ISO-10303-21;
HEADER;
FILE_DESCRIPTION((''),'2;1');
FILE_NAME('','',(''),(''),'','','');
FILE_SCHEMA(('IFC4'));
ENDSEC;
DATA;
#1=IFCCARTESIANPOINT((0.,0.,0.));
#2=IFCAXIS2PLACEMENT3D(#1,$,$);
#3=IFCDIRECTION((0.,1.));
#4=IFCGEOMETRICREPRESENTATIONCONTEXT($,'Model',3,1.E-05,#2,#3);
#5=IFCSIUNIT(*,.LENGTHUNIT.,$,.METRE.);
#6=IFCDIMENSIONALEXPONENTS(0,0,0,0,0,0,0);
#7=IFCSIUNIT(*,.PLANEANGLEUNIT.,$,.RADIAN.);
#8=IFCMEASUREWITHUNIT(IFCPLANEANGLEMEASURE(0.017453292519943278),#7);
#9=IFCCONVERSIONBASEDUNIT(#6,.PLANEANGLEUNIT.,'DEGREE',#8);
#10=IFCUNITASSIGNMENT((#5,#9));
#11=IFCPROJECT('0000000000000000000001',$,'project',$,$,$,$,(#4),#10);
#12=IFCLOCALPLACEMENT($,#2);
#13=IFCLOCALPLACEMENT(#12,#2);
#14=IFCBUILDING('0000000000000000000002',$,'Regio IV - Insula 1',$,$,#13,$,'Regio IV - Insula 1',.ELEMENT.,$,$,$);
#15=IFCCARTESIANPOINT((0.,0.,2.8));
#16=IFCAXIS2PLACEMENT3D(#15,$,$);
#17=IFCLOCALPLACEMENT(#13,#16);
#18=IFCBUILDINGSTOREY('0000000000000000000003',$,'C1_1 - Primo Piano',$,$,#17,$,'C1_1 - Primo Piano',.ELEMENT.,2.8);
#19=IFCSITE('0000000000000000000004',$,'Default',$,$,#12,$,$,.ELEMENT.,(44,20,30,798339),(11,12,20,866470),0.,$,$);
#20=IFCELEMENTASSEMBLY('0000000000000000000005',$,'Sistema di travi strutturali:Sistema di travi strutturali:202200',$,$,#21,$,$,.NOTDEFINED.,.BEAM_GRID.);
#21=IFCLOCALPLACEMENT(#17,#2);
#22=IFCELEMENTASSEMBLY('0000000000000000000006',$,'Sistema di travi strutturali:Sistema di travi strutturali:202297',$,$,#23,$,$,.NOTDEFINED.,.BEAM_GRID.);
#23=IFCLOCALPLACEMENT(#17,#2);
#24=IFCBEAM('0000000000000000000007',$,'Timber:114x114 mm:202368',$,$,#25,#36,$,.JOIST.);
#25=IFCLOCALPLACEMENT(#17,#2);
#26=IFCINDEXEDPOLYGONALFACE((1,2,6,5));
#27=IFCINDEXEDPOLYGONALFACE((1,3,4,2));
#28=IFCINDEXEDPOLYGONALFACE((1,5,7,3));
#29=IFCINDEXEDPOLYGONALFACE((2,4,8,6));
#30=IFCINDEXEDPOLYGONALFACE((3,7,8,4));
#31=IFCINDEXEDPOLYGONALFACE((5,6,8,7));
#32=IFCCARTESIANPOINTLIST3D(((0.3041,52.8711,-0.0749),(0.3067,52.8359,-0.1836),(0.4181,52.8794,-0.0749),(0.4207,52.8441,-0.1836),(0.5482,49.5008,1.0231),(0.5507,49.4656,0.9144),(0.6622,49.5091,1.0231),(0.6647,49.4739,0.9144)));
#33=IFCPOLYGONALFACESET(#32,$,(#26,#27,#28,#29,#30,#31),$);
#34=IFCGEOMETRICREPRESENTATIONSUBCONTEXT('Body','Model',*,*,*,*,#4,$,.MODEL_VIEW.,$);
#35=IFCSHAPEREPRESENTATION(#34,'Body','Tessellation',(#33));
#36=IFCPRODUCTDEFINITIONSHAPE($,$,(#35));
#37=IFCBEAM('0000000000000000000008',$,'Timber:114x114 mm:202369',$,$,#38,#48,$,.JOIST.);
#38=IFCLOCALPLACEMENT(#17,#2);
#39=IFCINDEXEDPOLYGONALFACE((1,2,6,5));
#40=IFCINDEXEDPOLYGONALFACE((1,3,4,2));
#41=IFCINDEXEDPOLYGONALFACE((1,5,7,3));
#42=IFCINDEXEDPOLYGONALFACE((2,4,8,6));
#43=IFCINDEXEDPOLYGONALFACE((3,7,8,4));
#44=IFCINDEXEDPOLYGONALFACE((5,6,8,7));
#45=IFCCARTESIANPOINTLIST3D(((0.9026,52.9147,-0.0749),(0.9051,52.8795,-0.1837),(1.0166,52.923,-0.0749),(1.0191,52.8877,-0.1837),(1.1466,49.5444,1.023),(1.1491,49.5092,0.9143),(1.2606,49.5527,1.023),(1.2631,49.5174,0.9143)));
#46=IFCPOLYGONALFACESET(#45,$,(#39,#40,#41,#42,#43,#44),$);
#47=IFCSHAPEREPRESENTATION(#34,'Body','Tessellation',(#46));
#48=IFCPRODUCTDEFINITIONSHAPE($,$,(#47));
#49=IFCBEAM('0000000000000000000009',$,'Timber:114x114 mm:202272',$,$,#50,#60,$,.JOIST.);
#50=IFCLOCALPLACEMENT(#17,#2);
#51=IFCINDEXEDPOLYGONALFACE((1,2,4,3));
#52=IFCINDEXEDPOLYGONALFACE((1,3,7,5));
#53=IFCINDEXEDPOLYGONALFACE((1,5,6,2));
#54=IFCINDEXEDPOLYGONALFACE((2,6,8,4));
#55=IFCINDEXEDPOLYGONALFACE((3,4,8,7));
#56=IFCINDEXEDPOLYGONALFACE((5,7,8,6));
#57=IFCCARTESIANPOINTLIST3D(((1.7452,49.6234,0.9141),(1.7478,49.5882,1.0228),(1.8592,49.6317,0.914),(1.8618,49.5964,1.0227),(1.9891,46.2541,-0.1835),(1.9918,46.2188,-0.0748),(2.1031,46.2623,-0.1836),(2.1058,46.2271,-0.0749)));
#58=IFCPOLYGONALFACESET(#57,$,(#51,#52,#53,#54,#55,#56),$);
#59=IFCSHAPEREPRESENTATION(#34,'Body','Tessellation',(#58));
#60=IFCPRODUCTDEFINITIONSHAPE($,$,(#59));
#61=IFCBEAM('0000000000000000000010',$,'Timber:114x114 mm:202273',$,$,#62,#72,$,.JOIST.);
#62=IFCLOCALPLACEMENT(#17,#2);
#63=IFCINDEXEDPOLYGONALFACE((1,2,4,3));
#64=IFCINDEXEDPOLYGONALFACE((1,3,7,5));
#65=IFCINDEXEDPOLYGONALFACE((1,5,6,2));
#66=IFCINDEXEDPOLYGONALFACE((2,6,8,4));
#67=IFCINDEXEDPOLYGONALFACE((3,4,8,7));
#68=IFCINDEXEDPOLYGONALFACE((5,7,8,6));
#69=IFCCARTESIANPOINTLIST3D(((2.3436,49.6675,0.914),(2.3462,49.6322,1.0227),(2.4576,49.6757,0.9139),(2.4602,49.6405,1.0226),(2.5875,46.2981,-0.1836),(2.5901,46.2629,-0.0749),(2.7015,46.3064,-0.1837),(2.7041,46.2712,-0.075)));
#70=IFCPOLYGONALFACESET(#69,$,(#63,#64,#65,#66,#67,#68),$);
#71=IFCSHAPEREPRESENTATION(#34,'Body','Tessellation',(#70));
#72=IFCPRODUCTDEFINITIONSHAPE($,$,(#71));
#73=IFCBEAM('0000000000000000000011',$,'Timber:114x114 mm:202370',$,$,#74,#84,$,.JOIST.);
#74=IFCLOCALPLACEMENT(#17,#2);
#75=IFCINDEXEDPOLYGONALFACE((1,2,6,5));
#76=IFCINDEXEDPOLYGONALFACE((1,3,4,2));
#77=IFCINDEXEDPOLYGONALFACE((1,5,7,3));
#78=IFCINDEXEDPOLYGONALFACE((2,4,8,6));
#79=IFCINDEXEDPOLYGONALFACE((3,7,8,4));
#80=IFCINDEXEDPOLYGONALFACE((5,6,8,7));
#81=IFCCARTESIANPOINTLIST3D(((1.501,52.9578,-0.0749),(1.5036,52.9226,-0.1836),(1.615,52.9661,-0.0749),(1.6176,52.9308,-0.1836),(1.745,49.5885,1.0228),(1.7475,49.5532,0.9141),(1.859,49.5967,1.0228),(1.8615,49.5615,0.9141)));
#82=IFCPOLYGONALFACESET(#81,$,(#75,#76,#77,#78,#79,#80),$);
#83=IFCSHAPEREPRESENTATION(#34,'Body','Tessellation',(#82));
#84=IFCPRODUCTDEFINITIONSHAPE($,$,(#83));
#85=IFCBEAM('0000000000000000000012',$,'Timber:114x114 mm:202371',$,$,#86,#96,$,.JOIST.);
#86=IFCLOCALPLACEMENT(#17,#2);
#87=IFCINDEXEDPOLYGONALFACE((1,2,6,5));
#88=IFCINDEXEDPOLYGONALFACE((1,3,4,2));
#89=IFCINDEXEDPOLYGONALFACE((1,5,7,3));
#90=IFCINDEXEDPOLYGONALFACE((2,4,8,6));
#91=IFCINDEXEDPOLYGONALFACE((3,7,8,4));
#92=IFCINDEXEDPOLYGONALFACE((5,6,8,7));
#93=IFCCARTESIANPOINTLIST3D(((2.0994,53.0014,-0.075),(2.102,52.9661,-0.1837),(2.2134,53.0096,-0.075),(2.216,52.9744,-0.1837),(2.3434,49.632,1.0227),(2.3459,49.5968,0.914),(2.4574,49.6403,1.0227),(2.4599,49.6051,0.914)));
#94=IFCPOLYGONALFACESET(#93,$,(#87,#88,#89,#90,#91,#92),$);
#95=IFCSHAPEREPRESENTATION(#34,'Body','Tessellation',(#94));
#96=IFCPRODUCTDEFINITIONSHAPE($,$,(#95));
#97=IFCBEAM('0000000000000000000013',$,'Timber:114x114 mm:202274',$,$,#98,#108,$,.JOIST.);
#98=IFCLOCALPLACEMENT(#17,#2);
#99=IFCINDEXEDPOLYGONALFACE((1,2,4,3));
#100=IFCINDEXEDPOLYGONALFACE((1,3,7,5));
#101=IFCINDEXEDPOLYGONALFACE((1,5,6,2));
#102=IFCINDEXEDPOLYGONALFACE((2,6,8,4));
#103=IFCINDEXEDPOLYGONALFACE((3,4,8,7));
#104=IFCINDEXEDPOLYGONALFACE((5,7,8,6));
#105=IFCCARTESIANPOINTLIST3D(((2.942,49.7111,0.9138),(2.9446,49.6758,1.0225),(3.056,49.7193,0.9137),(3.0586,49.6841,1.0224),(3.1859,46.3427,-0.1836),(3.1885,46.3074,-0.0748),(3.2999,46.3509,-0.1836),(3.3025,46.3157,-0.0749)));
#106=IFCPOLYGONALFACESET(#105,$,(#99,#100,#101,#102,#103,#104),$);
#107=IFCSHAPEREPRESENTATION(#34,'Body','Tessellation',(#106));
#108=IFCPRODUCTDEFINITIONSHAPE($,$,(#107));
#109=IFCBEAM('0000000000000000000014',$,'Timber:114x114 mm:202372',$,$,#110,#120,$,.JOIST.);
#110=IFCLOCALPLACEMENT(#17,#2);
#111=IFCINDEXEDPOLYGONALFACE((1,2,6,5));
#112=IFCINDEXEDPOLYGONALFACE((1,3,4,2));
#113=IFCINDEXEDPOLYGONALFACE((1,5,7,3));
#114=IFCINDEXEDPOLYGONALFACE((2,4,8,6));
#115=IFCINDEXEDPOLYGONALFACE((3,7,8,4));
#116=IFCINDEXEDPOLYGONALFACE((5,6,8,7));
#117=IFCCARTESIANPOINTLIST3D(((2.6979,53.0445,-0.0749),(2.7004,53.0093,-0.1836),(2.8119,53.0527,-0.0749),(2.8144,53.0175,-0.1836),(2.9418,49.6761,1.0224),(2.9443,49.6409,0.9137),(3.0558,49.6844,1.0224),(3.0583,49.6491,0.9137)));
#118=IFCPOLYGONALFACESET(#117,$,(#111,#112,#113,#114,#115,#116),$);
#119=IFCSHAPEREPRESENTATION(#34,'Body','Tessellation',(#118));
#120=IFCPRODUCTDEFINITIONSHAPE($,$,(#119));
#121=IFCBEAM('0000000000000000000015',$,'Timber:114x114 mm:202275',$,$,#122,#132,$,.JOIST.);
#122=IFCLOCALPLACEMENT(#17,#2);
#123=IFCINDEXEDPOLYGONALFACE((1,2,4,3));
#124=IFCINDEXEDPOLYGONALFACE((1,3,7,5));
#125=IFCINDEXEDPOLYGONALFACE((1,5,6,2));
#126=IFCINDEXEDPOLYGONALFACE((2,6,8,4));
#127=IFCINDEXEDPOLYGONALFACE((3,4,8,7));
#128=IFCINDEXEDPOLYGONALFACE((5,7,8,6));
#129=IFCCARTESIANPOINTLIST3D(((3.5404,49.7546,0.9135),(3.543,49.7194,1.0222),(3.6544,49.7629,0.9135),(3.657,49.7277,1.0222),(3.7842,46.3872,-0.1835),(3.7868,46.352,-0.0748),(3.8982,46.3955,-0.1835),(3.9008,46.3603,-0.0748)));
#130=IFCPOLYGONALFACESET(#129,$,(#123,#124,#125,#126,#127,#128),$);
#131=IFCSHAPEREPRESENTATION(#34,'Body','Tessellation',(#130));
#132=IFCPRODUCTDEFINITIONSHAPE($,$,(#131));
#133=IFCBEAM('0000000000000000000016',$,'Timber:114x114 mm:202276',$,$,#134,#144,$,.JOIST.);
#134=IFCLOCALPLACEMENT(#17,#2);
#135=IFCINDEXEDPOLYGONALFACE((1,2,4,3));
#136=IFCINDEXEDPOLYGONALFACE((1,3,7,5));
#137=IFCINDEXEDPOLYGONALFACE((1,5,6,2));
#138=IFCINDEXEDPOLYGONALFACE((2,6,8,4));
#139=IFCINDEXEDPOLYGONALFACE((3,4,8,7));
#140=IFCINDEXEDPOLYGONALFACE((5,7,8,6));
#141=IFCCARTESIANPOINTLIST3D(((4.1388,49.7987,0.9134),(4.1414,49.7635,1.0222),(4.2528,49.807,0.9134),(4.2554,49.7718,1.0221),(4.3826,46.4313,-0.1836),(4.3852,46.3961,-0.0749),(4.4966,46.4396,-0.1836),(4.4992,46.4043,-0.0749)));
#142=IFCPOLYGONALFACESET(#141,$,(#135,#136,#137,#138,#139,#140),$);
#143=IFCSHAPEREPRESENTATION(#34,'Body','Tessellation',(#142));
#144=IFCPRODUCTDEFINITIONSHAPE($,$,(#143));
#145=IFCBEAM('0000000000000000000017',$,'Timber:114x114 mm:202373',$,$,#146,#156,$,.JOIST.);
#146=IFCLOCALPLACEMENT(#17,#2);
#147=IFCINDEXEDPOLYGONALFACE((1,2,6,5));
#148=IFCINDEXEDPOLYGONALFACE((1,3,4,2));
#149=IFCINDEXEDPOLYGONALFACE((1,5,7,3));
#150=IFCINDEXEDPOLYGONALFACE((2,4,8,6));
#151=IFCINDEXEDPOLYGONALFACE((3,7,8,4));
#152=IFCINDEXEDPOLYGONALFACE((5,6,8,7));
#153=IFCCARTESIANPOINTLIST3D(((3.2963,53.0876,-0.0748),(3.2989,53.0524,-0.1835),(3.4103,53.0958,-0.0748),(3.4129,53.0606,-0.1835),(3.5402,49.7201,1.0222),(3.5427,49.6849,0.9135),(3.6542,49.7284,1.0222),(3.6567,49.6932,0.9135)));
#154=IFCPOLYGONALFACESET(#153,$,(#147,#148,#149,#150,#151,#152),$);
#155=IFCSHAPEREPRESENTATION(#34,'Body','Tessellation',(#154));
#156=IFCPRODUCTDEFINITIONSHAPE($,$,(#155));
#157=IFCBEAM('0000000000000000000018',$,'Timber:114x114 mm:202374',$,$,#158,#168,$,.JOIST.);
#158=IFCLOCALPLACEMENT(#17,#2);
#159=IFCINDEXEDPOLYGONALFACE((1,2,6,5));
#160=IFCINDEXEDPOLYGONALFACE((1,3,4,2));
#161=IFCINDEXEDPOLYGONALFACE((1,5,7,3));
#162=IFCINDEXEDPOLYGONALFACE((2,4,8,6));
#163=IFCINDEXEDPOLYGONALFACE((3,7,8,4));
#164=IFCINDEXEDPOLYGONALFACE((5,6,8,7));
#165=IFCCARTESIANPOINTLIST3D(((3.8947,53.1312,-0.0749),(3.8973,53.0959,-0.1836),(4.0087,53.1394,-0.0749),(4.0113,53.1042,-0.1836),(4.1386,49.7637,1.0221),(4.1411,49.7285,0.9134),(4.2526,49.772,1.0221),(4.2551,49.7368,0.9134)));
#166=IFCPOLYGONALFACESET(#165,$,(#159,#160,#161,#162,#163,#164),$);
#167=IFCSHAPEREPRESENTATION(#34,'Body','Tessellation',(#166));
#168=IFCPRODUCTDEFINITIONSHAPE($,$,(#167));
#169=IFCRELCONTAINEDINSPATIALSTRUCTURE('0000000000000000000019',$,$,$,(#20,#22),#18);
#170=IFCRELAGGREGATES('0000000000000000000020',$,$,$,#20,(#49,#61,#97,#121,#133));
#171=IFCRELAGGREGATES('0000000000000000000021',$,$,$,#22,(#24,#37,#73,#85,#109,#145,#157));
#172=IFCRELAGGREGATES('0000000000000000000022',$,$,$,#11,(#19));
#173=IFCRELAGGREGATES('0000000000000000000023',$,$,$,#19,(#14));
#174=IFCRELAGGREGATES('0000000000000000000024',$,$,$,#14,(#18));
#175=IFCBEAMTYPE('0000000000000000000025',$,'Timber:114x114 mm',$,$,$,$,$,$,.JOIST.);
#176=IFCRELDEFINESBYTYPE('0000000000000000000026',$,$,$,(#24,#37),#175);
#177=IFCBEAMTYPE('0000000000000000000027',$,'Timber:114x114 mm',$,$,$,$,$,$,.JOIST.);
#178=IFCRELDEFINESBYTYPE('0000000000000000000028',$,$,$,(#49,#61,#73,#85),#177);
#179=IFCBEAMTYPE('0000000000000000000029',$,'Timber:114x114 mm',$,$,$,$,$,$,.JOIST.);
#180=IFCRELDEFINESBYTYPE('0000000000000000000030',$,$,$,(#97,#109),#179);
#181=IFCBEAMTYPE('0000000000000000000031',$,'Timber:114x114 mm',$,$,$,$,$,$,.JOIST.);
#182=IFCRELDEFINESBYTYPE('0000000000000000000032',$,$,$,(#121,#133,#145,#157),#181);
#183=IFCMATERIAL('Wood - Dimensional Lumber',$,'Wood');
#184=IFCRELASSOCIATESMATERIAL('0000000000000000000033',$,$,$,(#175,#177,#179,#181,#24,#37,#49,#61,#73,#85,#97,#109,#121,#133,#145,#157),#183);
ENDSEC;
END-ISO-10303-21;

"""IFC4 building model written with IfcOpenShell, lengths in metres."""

from ifc_helpers import new_model, entity, si_unit, converted_unit, direction, frame, origin, origin_2d_with_axis, place, context, subcontext, project, spatial, rectangle, extrude, source, transform, mapped, material, material_profile, profile_set, profile_usage, type_object, type_shapes, element, aggregate, save


model = new_model("IFC4")

# Units and contexts
model_context = context("Model", 3, precision=1e-05, world=origin(), true_north=direction((0.0, 1.0)))
body_context = subcontext(model_context, "Body", "Model", "MODEL_VIEW")
ifc_project = project(units=[si_unit("LENGTHUNIT", "METRE"), converted_unit("PLANEANGLEUNIT", "DEGREE", entity("IfcPlaneAngleMeasure", 0.017453292519943278), si_unit("PLANEANGLEUNIT", "RADIAN"), dimensions=[0, 0, 0, 0, 0, 0, 0])], contexts=[model_context])

# Site, building, storey
site_placement = place(None, origin())
site = spatial("IfcSite", under=ifc_project, at=site_placement, Name="Default", CompositionType="ELEMENT", RefLatitude=(44, 20, 30, 798339), RefLongitude=(11, 12, 20, 866470), RefElevation=0.0)
building_placement = place(site_placement, origin())
building = spatial("IfcBuilding", under=site, at=building_placement, Name="Regio IV - Insula 1", LongName="Regio IV - Insula 1", CompositionType="ELEMENT")
storey_placement = place(building_placement, frame((0.0, 0.0, 2.8)))
storey = spatial("IfcBuildingStorey", under=building, at=storey_placement, Name="C1_1 - Primo Piano", LongName="C1_1 - Primo Piano", CompositionType="ELEMENT", Elevation=2.8)

# Element assembly
assembly_1_placement = place(storey_placement, origin())
assembly_1 = element("IfcElementAssembly", 1, at=assembly_1_placement, inside=storey, Name="Sistema di travi strutturali:Sistema di travi strutturali:202200", AssemblyPlace="NOTDEFINED", PredefinedType="BEAM_GRID")
ifc_material = material(Name="Wood - Dimensional Lumber", Category="Wood")
ifc_material_profile = material_profile(ifc_material, rectangle(XDim=5.294, YDim=0.1143, at=origin_2d_with_axis()), Name="114x114 mm")
ifc_profile_set = profile_set([ifc_material_profile], Name="114x114 mm")
ifc_profile_usage = profile_usage(ifc_profile_set, cardinal=8)

# Element assembly
assembly_2_placement = place(storey_placement, origin())
assembly_2 = element("IfcElementAssembly", 2, at=assembly_2_placement, inside=storey, Name="Sistema di travi strutturali:Sistema di travi strutturali:202297", AssemblyPlace="NOTDEFINED", PredefinedType="BEAM_GRID")

# Beams
beam_type_1 = type_object("IfcBeamType", Name="Timber:114x114 mm", PredefinedType="JOIST", material=ifc_profile_set)
shared_shape_1 = source(origin(), body_context, "Body", "SweptSolid", [
    extrude(rectangle(XDim=3.553, YDim=0.1143, at=origin_2d_with_axis()), frame((0.0, 0.0, -0.0572), z_axis=(0.0, 0.0, 1.0), x_axis=(-1.0, 0.0, 0.0)), (0.0, 0.0, 1.0), 0.1143),
])
type_shapes(beam_type_1, [shared_shape_1])
beam_1_placement = place(assembly_2_placement, frame((0.4844, 51.1725, 0.4197), z_axis=(-0.022317, 0.30821, 0.951057), x_axis=(0.068685, -0.948573, 0.309017)))
beam_1 = element("IfcBeam", 3, at=beam_1_placement, type_object=beam_type_1, material=ifc_profile_usage, Name="Timber:114x114 mm:202368", PredefinedType="JOIST", context=body_context, shape_type="MappedRepresentation", body=[
    mapped(shared_shape_1, transform((0.0, 0.0, 0.0), scale=1.0)),
])
beam_2_placement = place(assembly_2_placement, frame((1.0829, 51.2161, 0.4197), z_axis=(-0.022317, 0.30821, 0.951057), x_axis=(0.068685, -0.948573, 0.309017)))
beam_2 = element("IfcBeam", 4, at=beam_2_placement, type_object=beam_type_1, material=ifc_profile_usage, Name="Timber:114x114 mm:202369", PredefinedType="JOIST", context=body_context, shape_type="MappedRepresentation", body=[
    mapped(shared_shape_1, transform((0.0, 0.0, 0.0), scale=1.0)),
])
beam_type_2 = type_object("IfcBeamType", Name="Timber:114x114 mm", PredefinedType="JOIST", material=ifc_profile_set)
shared_shape_2 = source(origin(), body_context, "Body", "SweptSolid", [
    extrude(rectangle(XDim=3.552, YDim=0.1143, at=origin_2d_with_axis()), frame((0.0, 0.0, -0.0572), z_axis=(0.0, 0.0, 1.0), x_axis=(-1.0, 0.0, 0.0)), (0.0, 0.0, 1.0), 0.1143),
])
type_shapes(beam_type_2, [shared_shape_2])
beam_3_placement = place(assembly_1_placement, frame((1.9255, 47.9253, 0.4196), z_axis=(0.022823, -0.308173, 0.951057), x_axis=(0.068685, -0.948573, -0.309017)))
beam_3 = element("IfcBeam", 5, at=beam_3_placement, type_object=beam_type_2, material=ifc_profile_usage, Name="Timber:114x114 mm:202272", PredefinedType="JOIST", context=body_context, shape_type="MappedRepresentation", body=[
    mapped(shared_shape_2, transform((0.0, 0.0, 0.0), scale=1.0)),
])
beam_4_placement = place(assembly_1_placement, frame((2.5238, 47.9693, 0.4195), z_axis=(0.022823, -0.308173, 0.951057), x_axis=(0.068685, -0.948573, -0.309017)))
beam_4 = element("IfcBeam", 6, at=beam_4_placement, type_object=beam_type_2, material=ifc_profile_usage, Name="Timber:114x114 mm:202273", PredefinedType="JOIST", context=body_context, shape_type="MappedRepresentation", body=[
    mapped(shared_shape_2, transform((0.0, 0.0, 0.0), scale=1.0)),
])
beam_5_placement = place(assembly_2_placement, frame((1.6813, 51.2596, 0.4196), z_axis=(-0.022317, 0.30821, 0.951057), x_axis=(0.068685, -0.948573, 0.309017)))
beam_5 = element("IfcBeam", 7, at=beam_5_placement, type_object=beam_type_2, material=ifc_profile_usage, Name="Timber:114x114 mm:202370", PredefinedType="JOIST", context=body_context, shape_type="MappedRepresentation", body=[
    mapped(shared_shape_2, transform((0.0, 0.0, 0.0), scale=1.0)),
])
beam_6_placement = place(assembly_2_placement, frame((2.2797, 51.3032, 0.4195), z_axis=(-0.022317, 0.30821, 0.951057), x_axis=(0.068685, -0.948573, 0.309017)))
beam_6 = element("IfcBeam", 8, at=beam_6_placement, type_object=beam_type_2, material=ifc_profile_usage, Name="Timber:114x114 mm:202371", PredefinedType="JOIST", context=body_context, shape_type="MappedRepresentation", body=[
    mapped(shared_shape_2, transform((0.0, 0.0, 0.0), scale=1.0)),
])
beam_type_3 = type_object("IfcBeamType", Name="Timber:114x114 mm", PredefinedType="JOIST", material=ifc_profile_set)
shared_shape_3 = source(origin(), body_context, "Body", "SweptSolid", [
    extrude(rectangle(XDim=3.551, YDim=0.1143, at=origin_2d_with_axis()), frame((0.0, 0.0, -0.0572), z_axis=(0.0, 0.0, 1.0), x_axis=(-1.0, 0.0, 0.0)), (0.0, 0.0, 1.0), 0.1143),
])
type_shapes(beam_type_3, [shared_shape_3])
beam_7_placement = place(assembly_1_placement, frame((3.1222, 48.0134, 0.4194), z_axis=(0.022823, -0.308173, 0.951057), x_axis=(0.068685, -0.948573, -0.309017)))
beam_7 = element("IfcBeam", 9, at=beam_7_placement, type_object=beam_type_3, material=ifc_profile_usage, Name="Timber:114x114 mm:202274", PredefinedType="JOIST", context=body_context, shape_type="MappedRepresentation", body=[
    mapped(shared_shape_3, transform((0.0, 0.0, 0.0), scale=1.0)),
])
beam_8_placement = place(assembly_2_placement, frame((2.8781, 51.3468, 0.4194), z_axis=(-0.022317, 0.30821, 0.951057), x_axis=(0.068685, -0.948573, 0.309017)))
beam_8 = element("IfcBeam", 10, at=beam_8_placement, type_object=beam_type_3, material=ifc_profile_usage, Name="Timber:114x114 mm:202372", PredefinedType="JOIST", context=body_context, shape_type="MappedRepresentation", body=[
    mapped(shared_shape_3, transform((0.0, 0.0, 0.0), scale=1.0)),
])
beam_type_4 = type_object("IfcBeamType", Name="Timber:114x114 mm", PredefinedType="JOIST", material=ifc_profile_set)
shared_shape_4 = source(origin(), body_context, "Body", "SweptSolid", [
    extrude(rectangle(XDim=3.55, YDim=0.1143, at=origin_2d_with_axis()), frame((0.0, 0.0, -0.0572), z_axis=(0.0, 0.0, 1.0), x_axis=(-1.0, 0.0, 0.0)), (0.0, 0.0, 1.0), 0.1143),
])
type_shapes(beam_type_4, [shared_shape_4])
beam_9_placement = place(assembly_1_placement, frame((3.7206, 48.0575, 0.4193), z_axis=(0.022823, -0.308173, 0.951057), x_axis=(0.068685, -0.948573, -0.309017)))
beam_9 = element("IfcBeam", 11, at=beam_9_placement, type_object=beam_type_4, material=ifc_profile_usage, Name="Timber:114x114 mm:202275", PredefinedType="JOIST", context=body_context, shape_type="MappedRepresentation", body=[
    mapped(shared_shape_4, transform((0.0, 0.0, 0.0), scale=1.0)),
])
beam_10_placement = place(assembly_1_placement, frame((4.319, 48.1015, 0.4193), z_axis=(0.022823, -0.308173, 0.951057), x_axis=(0.068685, -0.948573, -0.309017)))
beam_10 = element("IfcBeam", 12, at=beam_10_placement, type_object=beam_type_4, material=ifc_profile_usage, Name="Timber:114x114 mm:202276", PredefinedType="JOIST", context=body_context, shape_type="MappedRepresentation", body=[
    mapped(shared_shape_4, transform((0.0, 0.0, 0.0), scale=1.0)),
])
aggregate(assembly_1, [beam_3, beam_4, beam_7, beam_9, beam_10])
beam_11_placement = place(assembly_2_placement, frame((3.4765, 51.3904, 0.4193), z_axis=(-0.022317, 0.30821, 0.951057), x_axis=(0.068685, -0.948573, 0.309017)))
beam_11 = element("IfcBeam", 13, at=beam_11_placement, type_object=beam_type_4, material=ifc_profile_usage, Name="Timber:114x114 mm:202373", PredefinedType="JOIST", context=body_context, shape_type="MappedRepresentation", body=[
    mapped(shared_shape_4, transform((0.0, 0.0, 0.0), scale=1.0)),
])
beam_12_placement = place(assembly_2_placement, frame((4.0749, 51.434, 0.4193), z_axis=(-0.022317, 0.30821, 0.951057), x_axis=(0.068685, -0.948573, 0.309017)))
beam_12 = element("IfcBeam", 14, at=beam_12_placement, type_object=beam_type_4, material=ifc_profile_usage, Name="Timber:114x114 mm:202374", PredefinedType="JOIST", context=body_context, shape_type="MappedRepresentation", body=[
    mapped(shared_shape_4, transform((0.0, 0.0, 0.0), scale=1.0)),
])
aggregate(assembly_2, [beam_1, beam_2, beam_5, beam_6, beam_8, beam_11, beam_12])

save(model, "model.ifc")
